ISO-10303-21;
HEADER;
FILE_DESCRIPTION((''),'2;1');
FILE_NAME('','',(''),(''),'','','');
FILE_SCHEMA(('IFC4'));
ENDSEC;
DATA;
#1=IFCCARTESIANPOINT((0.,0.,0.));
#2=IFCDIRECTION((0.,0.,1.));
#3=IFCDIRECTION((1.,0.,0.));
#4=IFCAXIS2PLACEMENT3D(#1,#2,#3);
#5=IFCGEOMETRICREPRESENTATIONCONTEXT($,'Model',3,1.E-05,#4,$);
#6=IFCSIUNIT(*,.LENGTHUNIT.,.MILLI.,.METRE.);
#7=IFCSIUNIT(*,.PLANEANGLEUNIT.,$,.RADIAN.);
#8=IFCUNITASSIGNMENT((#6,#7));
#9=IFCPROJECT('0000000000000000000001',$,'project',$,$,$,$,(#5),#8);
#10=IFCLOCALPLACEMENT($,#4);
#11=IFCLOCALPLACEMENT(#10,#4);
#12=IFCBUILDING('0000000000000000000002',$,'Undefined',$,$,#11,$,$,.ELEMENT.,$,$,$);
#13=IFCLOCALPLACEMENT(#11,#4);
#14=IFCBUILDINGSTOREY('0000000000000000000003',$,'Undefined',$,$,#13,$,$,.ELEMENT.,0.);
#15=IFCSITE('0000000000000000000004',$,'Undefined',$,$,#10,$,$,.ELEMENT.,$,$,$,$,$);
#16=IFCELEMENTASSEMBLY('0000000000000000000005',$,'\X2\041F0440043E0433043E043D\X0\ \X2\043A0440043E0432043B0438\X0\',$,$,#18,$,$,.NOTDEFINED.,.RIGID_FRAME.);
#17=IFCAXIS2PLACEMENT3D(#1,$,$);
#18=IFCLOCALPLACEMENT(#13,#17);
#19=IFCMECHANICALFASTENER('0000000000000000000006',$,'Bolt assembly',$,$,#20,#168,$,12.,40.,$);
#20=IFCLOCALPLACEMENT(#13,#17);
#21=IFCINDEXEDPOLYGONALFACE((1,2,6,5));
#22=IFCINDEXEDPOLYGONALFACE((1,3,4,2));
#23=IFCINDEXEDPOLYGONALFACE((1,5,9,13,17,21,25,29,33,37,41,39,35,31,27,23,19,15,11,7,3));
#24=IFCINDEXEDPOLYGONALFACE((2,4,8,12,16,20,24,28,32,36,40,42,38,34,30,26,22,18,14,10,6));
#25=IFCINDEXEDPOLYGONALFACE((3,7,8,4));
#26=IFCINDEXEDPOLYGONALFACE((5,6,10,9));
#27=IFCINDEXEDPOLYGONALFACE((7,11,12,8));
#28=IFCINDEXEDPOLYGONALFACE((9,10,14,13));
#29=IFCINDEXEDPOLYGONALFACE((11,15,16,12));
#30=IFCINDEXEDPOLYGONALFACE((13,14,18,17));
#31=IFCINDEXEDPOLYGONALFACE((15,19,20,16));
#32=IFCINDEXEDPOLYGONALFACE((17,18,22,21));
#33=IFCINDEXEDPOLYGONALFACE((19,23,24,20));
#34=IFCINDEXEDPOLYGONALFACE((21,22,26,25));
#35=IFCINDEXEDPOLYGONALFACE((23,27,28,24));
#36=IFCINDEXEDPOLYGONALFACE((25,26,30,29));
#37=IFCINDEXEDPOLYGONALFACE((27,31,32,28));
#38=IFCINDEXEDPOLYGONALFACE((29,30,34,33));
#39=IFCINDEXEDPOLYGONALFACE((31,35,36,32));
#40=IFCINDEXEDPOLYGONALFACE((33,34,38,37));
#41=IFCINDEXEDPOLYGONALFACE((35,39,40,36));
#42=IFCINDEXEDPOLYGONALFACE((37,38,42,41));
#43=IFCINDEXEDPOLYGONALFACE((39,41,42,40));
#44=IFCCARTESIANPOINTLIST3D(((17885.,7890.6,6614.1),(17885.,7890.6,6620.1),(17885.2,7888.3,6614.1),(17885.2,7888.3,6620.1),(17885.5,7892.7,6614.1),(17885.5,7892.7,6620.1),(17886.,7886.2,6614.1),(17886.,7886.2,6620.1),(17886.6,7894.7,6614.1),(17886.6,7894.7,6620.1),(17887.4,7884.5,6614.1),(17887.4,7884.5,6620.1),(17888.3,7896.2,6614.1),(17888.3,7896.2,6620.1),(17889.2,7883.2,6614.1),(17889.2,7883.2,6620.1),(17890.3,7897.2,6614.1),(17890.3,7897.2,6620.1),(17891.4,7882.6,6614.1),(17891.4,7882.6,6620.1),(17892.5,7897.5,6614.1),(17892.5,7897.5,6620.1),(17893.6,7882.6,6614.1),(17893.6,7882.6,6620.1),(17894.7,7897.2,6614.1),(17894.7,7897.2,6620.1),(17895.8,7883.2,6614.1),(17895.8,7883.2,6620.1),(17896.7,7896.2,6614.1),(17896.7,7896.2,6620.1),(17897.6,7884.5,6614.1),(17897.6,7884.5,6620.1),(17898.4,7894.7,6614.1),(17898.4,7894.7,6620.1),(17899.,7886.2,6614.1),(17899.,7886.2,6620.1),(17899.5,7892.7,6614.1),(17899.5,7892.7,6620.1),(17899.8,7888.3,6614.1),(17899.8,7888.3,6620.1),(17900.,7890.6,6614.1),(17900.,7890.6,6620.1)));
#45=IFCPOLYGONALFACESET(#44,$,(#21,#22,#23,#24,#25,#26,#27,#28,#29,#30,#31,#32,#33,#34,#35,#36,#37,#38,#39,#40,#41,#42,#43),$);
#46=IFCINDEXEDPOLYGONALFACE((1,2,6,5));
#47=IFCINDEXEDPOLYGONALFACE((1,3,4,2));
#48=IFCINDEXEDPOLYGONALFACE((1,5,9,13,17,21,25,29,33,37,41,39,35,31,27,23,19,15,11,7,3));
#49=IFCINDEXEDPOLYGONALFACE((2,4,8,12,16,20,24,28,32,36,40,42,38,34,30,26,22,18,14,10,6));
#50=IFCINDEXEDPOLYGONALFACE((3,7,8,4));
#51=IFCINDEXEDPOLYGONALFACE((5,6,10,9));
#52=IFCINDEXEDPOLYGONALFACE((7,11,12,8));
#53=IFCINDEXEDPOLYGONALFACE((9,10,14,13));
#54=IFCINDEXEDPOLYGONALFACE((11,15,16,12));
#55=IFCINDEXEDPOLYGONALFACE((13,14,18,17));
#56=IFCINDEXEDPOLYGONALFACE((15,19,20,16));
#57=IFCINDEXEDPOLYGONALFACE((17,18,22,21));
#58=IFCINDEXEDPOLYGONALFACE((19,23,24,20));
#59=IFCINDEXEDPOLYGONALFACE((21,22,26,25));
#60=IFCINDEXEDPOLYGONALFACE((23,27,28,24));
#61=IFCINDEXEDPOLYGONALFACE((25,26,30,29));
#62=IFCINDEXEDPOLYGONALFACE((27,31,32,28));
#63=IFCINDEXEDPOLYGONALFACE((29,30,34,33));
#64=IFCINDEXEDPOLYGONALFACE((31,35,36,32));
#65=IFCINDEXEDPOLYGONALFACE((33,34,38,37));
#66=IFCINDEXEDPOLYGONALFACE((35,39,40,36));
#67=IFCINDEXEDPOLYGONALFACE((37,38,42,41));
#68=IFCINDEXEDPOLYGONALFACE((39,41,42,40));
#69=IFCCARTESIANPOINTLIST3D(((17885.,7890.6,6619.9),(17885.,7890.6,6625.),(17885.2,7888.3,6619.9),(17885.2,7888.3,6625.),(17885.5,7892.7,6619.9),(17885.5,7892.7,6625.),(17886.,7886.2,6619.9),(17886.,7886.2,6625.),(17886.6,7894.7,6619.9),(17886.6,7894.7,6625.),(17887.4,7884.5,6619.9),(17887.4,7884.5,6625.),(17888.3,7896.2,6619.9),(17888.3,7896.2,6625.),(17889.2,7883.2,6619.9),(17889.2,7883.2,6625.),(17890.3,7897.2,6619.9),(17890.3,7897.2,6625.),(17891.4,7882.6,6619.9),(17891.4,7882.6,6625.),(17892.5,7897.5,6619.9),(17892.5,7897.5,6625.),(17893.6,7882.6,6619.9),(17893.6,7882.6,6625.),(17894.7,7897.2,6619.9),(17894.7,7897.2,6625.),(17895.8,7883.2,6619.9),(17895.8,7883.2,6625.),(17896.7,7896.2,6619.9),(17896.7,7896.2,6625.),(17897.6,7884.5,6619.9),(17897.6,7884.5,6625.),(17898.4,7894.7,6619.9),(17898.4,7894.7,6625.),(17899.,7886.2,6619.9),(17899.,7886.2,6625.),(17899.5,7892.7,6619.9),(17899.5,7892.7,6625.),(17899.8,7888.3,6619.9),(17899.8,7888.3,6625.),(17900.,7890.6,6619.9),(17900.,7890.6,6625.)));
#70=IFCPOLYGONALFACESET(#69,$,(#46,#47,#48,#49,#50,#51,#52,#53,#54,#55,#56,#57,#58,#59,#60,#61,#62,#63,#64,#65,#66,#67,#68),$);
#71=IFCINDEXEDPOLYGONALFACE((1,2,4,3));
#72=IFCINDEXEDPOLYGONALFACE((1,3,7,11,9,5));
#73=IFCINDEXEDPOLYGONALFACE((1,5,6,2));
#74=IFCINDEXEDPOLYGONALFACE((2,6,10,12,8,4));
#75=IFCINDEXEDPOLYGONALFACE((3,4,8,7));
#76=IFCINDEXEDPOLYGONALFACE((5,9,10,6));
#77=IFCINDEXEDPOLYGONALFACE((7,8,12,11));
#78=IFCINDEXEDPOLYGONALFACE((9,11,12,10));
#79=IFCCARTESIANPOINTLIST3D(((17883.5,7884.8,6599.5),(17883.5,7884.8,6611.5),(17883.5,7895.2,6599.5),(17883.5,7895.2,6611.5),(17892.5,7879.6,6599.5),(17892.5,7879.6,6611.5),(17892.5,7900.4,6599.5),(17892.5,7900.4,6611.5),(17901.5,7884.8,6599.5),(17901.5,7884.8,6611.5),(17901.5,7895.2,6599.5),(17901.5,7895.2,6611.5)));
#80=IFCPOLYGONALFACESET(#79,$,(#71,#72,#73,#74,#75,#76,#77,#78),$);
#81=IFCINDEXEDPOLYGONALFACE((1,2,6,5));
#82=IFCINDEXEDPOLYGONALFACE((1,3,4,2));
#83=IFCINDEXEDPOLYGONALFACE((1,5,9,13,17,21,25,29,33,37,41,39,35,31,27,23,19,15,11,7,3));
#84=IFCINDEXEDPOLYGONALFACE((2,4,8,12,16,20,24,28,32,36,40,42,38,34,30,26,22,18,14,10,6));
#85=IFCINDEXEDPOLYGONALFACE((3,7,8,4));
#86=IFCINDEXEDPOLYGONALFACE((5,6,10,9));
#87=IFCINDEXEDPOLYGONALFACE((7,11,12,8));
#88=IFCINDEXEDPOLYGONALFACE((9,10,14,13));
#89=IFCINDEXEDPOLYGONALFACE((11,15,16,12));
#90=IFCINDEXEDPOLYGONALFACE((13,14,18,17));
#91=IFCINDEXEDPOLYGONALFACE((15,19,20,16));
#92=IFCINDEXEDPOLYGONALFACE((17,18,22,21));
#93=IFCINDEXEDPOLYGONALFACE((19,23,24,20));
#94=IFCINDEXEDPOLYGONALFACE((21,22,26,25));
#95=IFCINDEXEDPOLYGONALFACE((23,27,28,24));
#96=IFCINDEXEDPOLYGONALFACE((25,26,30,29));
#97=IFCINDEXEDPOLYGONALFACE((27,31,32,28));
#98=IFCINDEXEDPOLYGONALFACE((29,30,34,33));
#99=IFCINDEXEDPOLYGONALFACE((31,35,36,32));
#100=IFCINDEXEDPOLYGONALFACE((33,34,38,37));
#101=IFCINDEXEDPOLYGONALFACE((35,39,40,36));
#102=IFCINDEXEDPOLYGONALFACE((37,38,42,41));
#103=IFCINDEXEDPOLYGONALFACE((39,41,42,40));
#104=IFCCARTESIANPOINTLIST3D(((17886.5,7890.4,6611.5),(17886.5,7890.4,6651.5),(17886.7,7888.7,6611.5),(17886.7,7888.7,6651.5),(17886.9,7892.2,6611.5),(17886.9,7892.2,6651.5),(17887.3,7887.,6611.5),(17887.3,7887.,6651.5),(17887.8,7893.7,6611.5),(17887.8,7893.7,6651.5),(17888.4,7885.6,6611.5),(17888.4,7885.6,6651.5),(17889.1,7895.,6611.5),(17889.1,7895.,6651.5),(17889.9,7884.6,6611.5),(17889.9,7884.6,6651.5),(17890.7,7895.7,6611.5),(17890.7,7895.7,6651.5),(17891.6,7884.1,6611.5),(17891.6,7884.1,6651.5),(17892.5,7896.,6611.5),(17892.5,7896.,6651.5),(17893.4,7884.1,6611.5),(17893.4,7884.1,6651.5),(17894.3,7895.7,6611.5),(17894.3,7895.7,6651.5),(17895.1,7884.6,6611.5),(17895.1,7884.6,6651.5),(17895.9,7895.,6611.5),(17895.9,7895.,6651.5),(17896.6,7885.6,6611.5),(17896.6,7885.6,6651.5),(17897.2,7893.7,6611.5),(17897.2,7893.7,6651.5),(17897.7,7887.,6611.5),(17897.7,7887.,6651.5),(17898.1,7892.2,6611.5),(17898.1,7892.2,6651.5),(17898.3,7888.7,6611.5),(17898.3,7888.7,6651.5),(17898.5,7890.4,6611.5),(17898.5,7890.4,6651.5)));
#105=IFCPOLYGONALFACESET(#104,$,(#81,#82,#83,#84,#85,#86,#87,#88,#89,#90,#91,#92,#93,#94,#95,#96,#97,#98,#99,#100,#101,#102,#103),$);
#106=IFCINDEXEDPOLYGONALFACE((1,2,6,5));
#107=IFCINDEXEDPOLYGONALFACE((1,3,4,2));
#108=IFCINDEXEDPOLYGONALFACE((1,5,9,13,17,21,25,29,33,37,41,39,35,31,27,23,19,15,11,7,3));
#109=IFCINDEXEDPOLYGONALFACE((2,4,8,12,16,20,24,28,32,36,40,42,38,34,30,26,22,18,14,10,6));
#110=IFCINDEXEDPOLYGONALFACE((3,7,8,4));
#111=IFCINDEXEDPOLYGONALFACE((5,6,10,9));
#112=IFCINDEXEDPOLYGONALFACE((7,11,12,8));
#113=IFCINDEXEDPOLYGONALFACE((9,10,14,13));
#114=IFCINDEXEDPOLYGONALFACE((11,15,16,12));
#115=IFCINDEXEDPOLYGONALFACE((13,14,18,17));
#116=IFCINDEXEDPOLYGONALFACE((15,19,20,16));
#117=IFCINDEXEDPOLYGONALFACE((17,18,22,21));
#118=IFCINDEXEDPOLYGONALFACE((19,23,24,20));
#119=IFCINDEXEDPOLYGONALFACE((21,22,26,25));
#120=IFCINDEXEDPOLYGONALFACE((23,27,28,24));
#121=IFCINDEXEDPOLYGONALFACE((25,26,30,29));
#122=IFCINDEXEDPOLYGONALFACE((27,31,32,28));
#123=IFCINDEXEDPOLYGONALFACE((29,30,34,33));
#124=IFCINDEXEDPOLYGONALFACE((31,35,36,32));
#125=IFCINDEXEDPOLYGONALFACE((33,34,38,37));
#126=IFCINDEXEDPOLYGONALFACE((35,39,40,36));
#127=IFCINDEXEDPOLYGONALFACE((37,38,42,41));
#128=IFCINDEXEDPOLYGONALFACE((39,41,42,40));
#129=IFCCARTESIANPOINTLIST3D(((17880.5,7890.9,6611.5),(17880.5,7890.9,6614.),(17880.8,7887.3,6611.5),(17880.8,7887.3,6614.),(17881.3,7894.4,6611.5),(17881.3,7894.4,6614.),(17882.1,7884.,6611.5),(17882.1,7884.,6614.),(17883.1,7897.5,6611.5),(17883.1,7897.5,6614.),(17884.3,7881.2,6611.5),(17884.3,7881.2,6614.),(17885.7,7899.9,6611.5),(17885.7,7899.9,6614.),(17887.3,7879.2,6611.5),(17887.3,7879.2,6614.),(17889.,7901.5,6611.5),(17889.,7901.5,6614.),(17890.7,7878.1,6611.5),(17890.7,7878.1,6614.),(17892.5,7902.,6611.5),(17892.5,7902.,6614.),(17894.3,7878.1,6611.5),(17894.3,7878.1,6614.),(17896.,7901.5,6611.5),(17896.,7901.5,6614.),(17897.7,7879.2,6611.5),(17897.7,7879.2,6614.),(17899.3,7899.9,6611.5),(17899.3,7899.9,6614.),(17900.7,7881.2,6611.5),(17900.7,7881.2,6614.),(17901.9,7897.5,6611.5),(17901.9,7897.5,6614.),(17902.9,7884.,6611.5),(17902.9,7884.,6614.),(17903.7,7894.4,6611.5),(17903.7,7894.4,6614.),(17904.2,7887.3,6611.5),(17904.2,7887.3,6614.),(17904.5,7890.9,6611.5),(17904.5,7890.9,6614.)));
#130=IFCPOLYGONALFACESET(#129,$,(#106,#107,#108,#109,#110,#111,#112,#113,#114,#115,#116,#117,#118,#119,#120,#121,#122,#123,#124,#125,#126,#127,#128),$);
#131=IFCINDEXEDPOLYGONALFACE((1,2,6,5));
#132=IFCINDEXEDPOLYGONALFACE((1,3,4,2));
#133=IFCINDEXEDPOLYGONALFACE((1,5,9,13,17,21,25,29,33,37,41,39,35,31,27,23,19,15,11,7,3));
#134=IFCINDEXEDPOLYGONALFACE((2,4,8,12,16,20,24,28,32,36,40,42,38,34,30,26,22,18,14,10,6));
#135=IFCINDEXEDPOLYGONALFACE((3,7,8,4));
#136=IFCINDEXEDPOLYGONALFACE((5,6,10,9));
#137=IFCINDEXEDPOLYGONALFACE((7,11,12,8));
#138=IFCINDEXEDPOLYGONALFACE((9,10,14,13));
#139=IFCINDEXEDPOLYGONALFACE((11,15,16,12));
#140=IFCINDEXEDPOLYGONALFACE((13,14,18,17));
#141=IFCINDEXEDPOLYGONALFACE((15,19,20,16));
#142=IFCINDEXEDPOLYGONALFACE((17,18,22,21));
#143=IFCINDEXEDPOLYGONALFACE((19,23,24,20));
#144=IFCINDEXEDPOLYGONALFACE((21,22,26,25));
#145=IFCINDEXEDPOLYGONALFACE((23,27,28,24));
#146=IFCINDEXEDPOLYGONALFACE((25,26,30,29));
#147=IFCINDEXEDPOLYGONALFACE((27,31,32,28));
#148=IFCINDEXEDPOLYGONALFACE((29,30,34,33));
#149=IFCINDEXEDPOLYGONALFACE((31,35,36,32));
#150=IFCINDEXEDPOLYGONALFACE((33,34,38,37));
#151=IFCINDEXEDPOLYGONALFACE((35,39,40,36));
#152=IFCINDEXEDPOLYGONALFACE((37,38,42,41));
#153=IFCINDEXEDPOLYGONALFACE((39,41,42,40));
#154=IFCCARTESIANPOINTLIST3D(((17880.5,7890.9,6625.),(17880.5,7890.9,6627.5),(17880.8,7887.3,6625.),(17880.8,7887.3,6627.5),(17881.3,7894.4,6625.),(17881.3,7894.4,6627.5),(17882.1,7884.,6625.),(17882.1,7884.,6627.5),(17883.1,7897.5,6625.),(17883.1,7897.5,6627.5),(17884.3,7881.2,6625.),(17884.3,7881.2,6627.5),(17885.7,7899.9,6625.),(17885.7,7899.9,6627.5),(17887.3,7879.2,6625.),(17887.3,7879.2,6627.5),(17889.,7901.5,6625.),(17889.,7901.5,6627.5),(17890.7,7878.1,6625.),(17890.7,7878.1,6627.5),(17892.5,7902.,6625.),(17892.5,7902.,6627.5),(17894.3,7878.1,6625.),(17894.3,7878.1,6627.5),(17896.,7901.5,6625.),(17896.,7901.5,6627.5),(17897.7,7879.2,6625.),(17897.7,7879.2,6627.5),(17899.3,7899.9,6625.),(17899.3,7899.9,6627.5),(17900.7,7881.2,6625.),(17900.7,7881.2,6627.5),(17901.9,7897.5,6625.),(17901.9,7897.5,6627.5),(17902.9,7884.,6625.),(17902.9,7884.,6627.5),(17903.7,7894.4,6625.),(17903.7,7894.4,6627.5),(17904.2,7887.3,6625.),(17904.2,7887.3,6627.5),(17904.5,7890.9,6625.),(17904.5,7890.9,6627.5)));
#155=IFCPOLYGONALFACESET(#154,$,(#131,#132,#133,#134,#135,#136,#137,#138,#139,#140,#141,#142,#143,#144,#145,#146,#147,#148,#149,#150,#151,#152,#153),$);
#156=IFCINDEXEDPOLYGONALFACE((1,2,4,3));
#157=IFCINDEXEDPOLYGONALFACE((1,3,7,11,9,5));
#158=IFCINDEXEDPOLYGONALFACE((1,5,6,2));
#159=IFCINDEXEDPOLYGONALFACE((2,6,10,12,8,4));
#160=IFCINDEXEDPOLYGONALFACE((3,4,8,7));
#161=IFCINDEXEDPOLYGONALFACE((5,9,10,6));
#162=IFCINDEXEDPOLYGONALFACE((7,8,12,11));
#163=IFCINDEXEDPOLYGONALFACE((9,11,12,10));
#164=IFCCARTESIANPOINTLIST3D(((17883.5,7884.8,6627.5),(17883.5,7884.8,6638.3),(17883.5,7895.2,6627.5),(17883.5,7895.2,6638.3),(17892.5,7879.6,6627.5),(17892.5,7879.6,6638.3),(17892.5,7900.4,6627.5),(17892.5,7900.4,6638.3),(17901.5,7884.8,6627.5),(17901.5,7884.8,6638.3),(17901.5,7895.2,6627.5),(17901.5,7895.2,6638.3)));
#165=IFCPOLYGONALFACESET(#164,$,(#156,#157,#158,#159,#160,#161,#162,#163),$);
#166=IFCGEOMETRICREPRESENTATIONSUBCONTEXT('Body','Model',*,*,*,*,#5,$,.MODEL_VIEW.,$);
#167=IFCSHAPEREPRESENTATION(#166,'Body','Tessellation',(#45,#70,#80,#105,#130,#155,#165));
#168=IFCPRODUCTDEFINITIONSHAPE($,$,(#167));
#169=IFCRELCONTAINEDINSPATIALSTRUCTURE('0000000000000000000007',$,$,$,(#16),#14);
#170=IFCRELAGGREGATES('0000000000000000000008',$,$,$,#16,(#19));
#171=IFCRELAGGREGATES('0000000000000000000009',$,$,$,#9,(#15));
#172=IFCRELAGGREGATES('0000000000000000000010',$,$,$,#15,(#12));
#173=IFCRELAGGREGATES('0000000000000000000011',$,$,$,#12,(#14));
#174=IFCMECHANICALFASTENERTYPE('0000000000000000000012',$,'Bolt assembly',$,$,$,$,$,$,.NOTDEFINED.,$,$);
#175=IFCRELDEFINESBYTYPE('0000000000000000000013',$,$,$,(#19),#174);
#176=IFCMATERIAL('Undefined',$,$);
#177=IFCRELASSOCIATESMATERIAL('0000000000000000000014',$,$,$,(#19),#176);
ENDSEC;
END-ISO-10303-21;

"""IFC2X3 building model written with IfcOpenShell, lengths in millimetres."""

from ifc_helpers import new_model, si_unit, frame, origin_with_axes, origin_2d_with_axis, place, context, subcontext, project, spatial, polyline, circle, outline, extrude, source, transform, mapped, material, type_object, element, aggregate, save


model = new_model("IFC2X3")

# Units and contexts
model_context = context("Model", 3, precision=1e-05, world=origin_with_axes())
body_context = subcontext(model_context, "Body", "Model", "MODEL_VIEW")
ifc_project = project(units=[si_unit("LENGTHUNIT", "METRE", prefix="MILLI"), si_unit("PLANEANGLEUNIT", "RADIAN")], contexts=[model_context])

# Site, building, storey
site_placement = place(None, origin_with_axes())
site = spatial("IfcSite", under=ifc_project, at=site_placement, Name="Undefined", CompositionType="ELEMENT")
building_placement = place(site_placement, origin_with_axes())
building = spatial("IfcBuilding", under=site, at=building_placement, Name="Undefined", CompositionType="ELEMENT")
storey_placement = place(building_placement, origin_with_axes())
storey = spatial("IfcBuildingStorey", under=building, at=storey_placement, Name="Undefined", CompositionType="ELEMENT", Elevation=0.0)

# Element assembly
assembly_1_placement = place(storey_placement, origin_with_axes())
assembly_1 = element("IfcElementAssembly", 1, at=assembly_1_placement, inside=storey, Name="Прогон кровли", AssemblyPlace="NOTDEFINED", PredefinedType="RIGID_FRAME")

# Mechanical fastener
ifc_material_1 = material(Name="Undefined")
mechanical_fastener_type = type_object("IfcMechanicalFastenerType", Name="Bolt assembly")
shared_shape_1 = source(origin_with_axes(), body_context, "Body", "SweptSolid", [
    extrude(circle(Radius=7.5, at=origin_2d_with_axis()), frame((0.0, -5.9, 0.0), z_axis=(0.0, 1.0, 0.0), x_axis=(1.0, 0.0, 0.0)), (0.0, 0.0, 1.0), 6.0),
    extrude(circle(Radius=7.5, at=origin_2d_with_axis()), frame((0.0, -0.1, 0.0), z_axis=(0.0, 1.0, 0.0), x_axis=(1.0, 0.0, 0.0)), (0.0, 0.0, 1.0), 5.1),
    extrude(outline(polyline([(10.4, 0.0), (5.2, 9.0), (-5.2, 9.0), (-10.4, 0.0), (-5.2, -9.0), (5.2, -9.0), (10.4, 0.0)])), frame((0.0, -20.5, 0.0), z_axis=(0.0, 1.0, 0.0), x_axis=(1.0, 0.0, 0.0)), (0.0, 0.0, 1.0), 12.0),
    extrude(circle(Radius=6.0, at=origin_2d_with_axis()), frame((0.0, -8.5, 0.0), z_axis=(0.0, 1.0, 0.0), x_axis=(1.0, 0.0, 0.0)), (0.0, 0.0, 1.0), 40.0),
    extrude(circle(Radius=12.0, at=origin_2d_with_axis()), frame((0.0, -8.5, 0.0), z_axis=(0.0, 1.0, 0.0), x_axis=(1.0, 0.0, 0.0)), (0.0, 0.0, 1.0), 2.5),
    extrude(circle(Radius=12.0, at=origin_2d_with_axis()), frame((0.0, 5.0, 0.0), z_axis=(0.0, 1.0, 0.0), x_axis=(1.0, 0.0, 0.0)), (0.0, 0.0, 1.0), 2.5),
    extrude(outline(polyline([(10.4, 0.0), (5.2, 9.0), (-5.2, 9.0), (-10.4, 0.0), (-5.2, -9.0), (5.2, -9.0), (10.4, 0.0)])), frame((0.0, 7.5, 0.0), z_axis=(0.0, 1.0, 0.0), x_axis=(1.0, 0.0, 0.0)), (0.0, 0.0, 1.0), 10.8),
])
mechanical_fastener_1_placement = place(assembly_1_placement, frame((17892.5, 7890.0, 6620.0), z_axis=(1.0, 0.0, 0.0), x_axis=(0.0, 1.0, 0.0)))
mechanical_fastener_1 = element("IfcMechanicalFastener", 2, at=mechanical_fastener_1_placement, type_object=mechanical_fastener_type, material=ifc_material_1, Name="Bolt assembly", NominalDiameter=12.0, NominalLength=40.0, context=body_context, shape_type="MappedRepresentation", body=[
    mapped(shared_shape_1, transform((0.0, 0.0, 0.0))),
])
aggregate(assembly_1, [mechanical_fastener_1])

save(model, "model.ifc")
